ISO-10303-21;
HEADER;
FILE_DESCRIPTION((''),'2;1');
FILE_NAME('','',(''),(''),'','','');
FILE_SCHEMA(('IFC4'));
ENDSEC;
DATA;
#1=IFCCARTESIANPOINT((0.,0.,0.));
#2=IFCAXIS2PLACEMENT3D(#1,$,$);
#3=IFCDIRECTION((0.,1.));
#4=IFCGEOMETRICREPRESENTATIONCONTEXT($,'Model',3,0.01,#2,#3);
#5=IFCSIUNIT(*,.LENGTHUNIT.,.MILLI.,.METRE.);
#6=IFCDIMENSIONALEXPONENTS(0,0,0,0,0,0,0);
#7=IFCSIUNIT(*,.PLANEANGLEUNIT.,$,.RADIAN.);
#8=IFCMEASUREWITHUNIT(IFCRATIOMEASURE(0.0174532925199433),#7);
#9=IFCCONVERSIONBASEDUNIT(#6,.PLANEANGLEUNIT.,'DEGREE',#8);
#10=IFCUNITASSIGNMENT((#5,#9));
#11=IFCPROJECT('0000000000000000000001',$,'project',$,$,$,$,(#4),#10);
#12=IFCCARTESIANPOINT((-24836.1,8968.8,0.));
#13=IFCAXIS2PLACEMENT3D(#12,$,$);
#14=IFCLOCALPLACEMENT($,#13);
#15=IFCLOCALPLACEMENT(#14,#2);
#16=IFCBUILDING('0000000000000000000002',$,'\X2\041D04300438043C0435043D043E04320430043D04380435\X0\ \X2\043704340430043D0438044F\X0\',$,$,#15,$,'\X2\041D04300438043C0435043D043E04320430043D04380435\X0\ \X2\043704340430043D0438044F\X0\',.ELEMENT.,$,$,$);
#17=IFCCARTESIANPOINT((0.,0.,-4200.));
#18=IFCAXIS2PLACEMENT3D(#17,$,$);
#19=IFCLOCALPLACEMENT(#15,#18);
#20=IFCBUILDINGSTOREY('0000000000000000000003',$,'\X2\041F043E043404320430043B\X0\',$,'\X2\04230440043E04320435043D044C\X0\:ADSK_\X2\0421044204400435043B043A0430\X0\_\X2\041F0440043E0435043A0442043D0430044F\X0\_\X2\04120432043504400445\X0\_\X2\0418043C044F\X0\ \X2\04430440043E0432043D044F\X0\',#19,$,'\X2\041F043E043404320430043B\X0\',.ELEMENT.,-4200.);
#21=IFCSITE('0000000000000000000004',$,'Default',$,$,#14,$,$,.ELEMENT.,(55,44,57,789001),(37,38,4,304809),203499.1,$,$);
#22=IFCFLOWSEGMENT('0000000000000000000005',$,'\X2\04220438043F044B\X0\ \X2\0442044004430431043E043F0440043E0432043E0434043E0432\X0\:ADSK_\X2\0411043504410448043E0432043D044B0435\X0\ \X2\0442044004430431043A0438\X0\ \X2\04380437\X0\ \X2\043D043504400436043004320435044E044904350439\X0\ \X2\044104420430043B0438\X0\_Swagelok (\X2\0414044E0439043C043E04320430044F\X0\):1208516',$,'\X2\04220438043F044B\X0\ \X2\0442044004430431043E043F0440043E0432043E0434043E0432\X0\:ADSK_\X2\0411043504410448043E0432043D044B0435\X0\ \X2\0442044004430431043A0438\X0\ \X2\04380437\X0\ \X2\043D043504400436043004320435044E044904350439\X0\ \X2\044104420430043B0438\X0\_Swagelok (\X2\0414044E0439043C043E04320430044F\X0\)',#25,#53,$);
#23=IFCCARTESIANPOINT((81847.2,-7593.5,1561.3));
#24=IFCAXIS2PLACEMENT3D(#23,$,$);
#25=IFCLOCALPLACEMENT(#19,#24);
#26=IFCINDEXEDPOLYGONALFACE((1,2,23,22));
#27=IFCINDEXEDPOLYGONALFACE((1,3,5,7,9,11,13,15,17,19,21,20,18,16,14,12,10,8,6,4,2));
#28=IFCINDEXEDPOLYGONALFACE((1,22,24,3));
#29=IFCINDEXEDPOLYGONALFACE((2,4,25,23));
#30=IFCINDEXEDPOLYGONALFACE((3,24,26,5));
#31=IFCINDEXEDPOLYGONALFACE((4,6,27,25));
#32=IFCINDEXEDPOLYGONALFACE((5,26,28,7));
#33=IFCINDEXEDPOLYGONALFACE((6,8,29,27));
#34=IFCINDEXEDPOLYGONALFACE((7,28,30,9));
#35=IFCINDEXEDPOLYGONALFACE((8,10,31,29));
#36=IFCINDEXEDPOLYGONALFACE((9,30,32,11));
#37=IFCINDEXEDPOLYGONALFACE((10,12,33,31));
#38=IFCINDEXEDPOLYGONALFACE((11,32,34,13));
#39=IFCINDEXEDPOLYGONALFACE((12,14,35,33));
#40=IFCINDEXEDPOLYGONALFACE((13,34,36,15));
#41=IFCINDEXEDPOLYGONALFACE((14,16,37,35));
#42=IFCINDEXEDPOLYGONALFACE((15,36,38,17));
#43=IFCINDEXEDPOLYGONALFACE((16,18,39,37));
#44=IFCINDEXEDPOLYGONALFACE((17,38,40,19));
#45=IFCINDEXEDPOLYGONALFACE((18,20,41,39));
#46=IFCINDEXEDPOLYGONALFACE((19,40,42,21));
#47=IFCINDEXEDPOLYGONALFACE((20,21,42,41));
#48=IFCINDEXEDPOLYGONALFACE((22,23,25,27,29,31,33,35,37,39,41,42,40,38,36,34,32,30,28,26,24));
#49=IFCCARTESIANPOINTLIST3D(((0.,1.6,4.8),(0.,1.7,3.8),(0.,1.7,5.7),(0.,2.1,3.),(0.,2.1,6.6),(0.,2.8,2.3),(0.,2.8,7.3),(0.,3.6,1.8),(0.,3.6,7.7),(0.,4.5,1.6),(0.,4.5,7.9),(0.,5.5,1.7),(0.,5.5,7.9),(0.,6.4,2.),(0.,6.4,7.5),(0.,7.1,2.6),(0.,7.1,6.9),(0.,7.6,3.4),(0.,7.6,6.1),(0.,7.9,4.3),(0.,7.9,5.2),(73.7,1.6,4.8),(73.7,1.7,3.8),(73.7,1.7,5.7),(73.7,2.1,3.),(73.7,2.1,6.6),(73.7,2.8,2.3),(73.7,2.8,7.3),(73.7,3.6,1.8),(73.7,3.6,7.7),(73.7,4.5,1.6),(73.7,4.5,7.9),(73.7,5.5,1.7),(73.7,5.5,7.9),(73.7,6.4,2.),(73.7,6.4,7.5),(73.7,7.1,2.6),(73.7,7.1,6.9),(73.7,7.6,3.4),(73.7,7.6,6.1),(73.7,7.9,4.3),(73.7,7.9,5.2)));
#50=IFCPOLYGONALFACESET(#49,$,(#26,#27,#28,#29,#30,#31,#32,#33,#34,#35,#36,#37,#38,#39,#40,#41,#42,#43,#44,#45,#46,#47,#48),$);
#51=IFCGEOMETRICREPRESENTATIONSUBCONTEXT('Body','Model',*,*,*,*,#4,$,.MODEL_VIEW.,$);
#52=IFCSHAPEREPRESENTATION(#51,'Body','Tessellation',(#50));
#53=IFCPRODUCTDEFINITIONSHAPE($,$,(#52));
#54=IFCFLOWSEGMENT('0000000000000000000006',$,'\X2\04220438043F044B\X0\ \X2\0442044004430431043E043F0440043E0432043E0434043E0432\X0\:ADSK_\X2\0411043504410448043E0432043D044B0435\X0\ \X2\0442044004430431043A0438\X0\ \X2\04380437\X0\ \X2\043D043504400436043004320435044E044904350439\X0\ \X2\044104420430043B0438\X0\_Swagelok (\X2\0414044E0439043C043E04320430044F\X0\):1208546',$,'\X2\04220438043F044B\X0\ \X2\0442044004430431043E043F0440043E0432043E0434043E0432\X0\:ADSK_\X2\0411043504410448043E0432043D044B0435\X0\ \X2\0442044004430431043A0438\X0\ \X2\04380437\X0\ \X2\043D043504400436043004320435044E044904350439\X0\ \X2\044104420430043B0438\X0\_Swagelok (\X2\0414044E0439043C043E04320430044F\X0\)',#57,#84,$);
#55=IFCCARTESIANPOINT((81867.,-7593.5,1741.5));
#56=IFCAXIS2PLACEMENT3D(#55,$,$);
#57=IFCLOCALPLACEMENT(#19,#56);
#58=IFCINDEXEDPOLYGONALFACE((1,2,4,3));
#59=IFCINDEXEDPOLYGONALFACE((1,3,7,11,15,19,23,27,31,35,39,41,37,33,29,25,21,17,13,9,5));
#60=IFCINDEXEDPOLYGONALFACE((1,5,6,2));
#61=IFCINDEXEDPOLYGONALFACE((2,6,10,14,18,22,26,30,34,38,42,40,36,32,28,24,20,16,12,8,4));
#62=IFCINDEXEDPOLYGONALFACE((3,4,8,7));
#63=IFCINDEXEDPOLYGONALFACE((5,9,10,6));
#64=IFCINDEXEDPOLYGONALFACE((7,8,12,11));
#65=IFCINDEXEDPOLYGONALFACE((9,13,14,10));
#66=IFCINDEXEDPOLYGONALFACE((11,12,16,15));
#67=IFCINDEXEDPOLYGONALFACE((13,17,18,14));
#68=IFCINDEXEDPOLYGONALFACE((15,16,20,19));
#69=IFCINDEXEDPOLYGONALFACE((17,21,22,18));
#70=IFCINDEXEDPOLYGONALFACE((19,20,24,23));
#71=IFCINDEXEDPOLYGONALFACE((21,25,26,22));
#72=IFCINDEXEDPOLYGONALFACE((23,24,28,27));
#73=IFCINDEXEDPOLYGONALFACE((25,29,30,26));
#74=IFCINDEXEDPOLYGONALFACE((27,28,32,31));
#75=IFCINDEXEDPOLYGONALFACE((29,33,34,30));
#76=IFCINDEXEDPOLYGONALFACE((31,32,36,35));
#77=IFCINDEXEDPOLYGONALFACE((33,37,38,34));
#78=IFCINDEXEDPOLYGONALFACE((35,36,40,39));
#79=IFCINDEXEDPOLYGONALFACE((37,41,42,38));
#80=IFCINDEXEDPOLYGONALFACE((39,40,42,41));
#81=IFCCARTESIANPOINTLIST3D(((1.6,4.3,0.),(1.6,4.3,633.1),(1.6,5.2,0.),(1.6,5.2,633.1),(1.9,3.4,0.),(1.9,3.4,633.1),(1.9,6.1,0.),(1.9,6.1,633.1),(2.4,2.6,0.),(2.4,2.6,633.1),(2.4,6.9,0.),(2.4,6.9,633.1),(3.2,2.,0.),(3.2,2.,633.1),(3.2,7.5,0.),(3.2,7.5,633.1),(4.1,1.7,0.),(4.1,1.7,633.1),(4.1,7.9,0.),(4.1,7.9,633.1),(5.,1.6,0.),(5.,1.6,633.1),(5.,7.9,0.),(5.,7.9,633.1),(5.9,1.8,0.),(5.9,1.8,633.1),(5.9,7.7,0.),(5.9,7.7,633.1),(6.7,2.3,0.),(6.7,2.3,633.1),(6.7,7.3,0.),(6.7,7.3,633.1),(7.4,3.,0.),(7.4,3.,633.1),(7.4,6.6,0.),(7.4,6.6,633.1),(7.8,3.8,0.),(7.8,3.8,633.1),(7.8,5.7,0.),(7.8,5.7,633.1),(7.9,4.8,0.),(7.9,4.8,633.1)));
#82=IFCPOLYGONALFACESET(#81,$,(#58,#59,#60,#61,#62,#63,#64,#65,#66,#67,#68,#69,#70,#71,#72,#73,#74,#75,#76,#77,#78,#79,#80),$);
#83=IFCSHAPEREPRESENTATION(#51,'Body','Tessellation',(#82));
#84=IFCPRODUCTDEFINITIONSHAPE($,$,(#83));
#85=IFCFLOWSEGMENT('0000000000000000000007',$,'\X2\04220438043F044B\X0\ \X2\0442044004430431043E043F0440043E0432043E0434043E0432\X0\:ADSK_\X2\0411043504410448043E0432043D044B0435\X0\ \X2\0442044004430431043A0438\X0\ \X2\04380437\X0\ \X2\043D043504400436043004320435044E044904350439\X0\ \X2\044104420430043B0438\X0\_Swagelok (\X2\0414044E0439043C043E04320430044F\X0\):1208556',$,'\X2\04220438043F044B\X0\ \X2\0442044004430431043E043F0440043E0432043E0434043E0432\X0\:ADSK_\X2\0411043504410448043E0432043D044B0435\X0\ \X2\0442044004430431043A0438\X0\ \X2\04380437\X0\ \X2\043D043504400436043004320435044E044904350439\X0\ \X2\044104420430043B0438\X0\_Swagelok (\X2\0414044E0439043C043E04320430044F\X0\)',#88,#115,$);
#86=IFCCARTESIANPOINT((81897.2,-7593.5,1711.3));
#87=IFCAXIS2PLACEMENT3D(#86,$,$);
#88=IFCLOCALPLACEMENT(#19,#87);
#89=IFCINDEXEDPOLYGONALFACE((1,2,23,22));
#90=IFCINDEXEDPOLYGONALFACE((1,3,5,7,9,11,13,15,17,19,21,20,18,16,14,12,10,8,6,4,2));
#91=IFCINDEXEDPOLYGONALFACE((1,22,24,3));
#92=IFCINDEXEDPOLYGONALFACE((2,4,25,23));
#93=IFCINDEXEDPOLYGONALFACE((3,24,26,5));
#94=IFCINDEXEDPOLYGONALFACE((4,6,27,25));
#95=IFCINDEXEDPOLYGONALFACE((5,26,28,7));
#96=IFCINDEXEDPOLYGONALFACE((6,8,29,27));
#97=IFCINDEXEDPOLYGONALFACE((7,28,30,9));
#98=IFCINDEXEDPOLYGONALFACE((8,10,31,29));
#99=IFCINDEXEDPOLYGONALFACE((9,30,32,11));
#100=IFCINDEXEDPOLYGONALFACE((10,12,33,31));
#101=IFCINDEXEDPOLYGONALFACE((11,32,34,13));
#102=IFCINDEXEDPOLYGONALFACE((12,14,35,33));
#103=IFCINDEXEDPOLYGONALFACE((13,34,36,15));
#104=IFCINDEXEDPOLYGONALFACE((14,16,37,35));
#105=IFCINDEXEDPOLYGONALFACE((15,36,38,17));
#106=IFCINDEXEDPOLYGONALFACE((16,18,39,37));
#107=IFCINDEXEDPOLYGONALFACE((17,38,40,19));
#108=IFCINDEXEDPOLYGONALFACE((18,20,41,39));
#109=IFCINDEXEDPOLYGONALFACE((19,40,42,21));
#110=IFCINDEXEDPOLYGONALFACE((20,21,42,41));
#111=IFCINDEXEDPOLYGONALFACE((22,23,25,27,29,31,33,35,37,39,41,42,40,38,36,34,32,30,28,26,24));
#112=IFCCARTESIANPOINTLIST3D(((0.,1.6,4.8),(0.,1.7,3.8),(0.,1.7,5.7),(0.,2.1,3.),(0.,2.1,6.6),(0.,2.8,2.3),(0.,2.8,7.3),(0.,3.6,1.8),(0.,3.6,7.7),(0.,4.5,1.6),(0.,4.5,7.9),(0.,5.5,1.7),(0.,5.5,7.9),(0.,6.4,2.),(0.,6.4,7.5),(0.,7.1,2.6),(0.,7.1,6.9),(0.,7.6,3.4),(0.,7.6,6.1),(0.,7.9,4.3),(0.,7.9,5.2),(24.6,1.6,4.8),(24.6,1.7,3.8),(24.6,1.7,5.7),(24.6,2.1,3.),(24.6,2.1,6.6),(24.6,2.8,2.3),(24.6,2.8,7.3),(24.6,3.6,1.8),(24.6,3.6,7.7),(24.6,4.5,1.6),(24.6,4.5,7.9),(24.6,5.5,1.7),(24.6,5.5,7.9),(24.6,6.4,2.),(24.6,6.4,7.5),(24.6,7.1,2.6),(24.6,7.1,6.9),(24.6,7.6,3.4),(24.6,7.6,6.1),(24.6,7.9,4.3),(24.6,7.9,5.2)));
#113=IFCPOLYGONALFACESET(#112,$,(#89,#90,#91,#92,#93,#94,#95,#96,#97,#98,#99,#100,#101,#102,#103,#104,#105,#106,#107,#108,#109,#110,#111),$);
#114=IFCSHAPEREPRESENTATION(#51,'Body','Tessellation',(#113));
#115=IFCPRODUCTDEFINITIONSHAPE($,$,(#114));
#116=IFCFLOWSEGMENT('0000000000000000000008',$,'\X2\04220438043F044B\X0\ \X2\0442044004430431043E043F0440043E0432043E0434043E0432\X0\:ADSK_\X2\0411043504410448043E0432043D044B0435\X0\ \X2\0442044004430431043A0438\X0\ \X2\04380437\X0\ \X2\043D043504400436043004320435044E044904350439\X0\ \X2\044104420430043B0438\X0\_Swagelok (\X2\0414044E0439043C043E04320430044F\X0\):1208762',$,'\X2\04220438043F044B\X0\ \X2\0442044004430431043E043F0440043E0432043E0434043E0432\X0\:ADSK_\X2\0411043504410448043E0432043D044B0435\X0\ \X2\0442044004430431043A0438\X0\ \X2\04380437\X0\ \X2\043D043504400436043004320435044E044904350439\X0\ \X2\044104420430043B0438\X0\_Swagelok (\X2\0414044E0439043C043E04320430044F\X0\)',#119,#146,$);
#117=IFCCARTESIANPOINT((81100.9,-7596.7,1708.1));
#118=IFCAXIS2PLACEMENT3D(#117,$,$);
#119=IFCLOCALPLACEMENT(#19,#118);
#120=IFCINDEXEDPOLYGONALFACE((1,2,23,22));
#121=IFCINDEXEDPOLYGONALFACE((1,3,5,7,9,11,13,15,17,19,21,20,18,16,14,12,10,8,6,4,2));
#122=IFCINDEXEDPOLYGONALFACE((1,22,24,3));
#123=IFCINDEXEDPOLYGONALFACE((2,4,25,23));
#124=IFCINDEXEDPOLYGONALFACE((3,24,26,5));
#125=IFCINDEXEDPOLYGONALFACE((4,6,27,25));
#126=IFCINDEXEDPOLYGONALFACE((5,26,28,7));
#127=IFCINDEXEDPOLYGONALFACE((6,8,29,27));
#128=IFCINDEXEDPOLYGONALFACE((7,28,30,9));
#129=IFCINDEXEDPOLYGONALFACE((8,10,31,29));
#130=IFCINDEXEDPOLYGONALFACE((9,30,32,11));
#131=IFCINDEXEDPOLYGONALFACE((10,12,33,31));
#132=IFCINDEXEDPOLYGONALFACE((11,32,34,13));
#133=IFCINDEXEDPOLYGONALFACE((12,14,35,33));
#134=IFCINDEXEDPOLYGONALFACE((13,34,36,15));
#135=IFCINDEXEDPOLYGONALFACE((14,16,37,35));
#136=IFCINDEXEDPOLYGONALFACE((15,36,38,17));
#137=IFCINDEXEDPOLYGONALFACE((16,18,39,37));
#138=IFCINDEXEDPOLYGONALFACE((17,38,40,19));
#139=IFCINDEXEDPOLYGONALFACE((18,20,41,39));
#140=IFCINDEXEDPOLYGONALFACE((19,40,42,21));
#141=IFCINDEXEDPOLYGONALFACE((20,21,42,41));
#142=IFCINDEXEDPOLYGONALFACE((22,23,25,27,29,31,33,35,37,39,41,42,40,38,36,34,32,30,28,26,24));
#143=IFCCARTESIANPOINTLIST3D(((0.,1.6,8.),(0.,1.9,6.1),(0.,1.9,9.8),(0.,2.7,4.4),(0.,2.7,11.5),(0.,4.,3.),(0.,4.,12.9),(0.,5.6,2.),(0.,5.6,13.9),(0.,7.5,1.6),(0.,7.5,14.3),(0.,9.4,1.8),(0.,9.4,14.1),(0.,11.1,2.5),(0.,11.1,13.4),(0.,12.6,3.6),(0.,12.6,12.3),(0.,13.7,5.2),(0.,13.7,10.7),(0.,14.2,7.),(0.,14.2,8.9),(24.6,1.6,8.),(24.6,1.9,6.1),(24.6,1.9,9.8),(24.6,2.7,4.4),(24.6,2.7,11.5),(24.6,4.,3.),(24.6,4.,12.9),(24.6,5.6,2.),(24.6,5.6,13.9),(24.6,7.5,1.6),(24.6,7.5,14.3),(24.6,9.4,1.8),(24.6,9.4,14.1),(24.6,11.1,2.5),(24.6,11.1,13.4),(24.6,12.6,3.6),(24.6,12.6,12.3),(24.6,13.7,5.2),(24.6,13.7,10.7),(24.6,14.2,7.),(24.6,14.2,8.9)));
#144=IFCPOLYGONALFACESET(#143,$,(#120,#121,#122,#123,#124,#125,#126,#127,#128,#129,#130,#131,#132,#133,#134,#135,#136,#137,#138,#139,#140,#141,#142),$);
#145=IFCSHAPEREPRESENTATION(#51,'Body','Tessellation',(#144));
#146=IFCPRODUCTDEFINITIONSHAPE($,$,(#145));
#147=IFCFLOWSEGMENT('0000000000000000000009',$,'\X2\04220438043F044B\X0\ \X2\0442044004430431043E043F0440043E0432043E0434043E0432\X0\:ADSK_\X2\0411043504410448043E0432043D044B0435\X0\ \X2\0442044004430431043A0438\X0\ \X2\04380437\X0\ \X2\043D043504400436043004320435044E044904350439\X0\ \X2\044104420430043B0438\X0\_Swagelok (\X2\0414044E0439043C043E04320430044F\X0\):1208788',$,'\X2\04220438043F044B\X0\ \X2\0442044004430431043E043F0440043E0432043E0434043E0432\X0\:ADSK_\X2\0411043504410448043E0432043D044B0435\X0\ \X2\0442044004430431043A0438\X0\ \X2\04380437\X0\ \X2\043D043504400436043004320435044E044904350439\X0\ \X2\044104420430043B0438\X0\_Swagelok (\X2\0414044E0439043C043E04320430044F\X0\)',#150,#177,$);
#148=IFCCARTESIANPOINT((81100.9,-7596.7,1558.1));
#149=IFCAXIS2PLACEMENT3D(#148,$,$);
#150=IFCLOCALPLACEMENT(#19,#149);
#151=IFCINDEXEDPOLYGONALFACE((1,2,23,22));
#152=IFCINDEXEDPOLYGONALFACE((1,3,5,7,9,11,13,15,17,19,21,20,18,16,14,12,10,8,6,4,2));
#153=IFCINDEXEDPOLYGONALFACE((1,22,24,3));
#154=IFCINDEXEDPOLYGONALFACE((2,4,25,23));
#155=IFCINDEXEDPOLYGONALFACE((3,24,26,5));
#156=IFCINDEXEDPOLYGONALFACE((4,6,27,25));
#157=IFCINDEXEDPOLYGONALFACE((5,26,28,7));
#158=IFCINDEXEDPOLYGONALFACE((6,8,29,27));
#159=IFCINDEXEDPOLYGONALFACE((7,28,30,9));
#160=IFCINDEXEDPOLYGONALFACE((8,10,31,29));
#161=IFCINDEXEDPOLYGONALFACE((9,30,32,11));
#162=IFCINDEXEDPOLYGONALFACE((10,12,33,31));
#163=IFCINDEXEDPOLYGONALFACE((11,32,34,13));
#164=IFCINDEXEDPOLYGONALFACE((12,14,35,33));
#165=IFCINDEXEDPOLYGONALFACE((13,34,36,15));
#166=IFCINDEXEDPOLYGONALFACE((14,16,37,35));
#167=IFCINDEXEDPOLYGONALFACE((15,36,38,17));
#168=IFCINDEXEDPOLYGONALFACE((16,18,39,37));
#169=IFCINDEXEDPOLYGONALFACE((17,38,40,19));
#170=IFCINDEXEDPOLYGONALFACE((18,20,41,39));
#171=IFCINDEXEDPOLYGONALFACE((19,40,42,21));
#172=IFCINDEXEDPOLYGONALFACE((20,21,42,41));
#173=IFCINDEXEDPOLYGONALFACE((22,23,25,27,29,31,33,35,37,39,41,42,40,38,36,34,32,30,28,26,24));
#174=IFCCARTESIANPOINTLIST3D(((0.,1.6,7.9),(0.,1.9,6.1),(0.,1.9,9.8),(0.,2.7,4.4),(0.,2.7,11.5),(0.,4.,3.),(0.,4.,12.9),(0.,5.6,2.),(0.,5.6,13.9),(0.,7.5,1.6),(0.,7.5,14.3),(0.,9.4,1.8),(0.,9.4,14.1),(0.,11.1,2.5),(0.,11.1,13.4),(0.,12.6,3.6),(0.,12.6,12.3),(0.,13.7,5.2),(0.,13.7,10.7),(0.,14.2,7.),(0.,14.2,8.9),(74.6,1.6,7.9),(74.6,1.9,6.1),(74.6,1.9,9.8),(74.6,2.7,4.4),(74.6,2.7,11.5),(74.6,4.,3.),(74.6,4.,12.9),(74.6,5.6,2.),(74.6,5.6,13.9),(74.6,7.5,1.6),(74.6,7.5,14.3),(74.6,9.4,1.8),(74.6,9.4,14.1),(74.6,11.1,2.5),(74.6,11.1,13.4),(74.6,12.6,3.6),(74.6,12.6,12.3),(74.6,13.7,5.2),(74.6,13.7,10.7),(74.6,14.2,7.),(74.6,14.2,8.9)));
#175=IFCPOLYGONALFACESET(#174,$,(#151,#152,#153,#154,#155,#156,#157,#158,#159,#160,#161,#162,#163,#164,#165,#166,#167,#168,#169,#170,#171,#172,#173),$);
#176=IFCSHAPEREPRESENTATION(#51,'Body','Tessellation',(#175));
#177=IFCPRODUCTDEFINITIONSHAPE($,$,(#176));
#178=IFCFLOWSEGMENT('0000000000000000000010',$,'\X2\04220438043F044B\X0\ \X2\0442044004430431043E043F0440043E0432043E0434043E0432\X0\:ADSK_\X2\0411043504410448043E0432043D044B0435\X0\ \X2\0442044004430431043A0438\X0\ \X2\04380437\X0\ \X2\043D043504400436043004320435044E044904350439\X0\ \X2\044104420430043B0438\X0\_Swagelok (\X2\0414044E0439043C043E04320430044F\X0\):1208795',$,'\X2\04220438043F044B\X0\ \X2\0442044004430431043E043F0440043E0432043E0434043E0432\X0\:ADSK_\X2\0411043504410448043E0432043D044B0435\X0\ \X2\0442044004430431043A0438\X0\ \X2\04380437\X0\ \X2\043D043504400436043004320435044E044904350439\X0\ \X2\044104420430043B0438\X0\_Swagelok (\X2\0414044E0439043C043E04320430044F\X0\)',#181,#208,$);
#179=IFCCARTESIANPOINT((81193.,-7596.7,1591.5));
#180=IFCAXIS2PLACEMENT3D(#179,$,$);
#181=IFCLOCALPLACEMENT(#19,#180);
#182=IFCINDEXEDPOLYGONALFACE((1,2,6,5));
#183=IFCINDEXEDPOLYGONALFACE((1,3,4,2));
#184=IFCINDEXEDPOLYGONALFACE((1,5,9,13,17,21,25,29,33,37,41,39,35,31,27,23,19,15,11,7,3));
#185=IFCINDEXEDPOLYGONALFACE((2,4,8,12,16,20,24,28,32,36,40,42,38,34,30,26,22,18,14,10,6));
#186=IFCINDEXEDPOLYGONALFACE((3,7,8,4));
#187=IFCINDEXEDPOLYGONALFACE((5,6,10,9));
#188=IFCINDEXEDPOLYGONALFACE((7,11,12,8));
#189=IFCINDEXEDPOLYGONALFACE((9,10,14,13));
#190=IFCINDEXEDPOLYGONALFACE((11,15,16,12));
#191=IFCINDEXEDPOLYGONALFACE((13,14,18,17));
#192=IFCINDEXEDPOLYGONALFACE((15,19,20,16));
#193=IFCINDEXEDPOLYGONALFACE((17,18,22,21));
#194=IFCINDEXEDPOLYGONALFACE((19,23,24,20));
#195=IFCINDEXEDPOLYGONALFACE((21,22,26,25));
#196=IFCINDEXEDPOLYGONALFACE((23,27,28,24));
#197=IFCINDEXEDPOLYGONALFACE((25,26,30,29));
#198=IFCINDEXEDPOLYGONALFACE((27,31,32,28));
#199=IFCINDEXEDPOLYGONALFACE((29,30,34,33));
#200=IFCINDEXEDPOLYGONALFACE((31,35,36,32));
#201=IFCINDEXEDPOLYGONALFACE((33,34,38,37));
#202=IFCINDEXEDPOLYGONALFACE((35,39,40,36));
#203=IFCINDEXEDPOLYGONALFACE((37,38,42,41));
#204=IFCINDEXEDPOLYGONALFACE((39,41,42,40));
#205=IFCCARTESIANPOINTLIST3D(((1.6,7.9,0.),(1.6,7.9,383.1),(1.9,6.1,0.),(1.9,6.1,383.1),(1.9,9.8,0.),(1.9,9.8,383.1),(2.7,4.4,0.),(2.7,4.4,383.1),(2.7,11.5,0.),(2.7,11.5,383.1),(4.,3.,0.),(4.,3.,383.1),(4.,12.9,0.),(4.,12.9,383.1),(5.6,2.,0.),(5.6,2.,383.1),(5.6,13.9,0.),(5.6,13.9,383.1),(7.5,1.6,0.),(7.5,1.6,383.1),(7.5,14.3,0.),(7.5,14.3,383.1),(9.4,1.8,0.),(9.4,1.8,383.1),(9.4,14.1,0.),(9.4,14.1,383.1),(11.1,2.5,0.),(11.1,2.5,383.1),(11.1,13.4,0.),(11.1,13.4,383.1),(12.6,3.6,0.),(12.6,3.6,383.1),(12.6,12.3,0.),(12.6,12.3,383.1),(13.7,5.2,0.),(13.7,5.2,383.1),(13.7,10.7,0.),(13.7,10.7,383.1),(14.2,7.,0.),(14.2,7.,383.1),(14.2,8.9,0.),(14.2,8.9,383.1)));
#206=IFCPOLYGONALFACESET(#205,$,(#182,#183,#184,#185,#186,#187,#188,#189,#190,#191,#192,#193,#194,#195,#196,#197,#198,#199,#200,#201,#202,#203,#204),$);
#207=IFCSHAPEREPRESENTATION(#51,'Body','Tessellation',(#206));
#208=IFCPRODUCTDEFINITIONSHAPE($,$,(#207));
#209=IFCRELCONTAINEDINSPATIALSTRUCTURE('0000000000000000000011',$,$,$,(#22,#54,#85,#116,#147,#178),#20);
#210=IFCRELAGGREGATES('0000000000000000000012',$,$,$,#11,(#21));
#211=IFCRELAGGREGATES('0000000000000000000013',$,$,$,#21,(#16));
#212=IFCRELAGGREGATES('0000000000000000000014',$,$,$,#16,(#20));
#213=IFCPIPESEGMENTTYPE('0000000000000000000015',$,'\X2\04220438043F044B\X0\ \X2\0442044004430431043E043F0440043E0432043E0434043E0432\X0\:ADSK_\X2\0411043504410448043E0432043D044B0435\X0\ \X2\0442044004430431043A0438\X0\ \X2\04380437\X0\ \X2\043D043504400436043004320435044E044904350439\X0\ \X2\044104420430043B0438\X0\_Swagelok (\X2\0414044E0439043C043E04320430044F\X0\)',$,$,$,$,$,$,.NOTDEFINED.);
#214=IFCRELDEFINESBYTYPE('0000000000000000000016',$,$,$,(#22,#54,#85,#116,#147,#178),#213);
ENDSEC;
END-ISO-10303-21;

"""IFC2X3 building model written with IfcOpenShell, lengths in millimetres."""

from ifc_helpers import new_model, entity, si_unit, converted_unit, direction, frame, origin, origin_2d_with_axis, place, context, subcontext, project, spatial, circle, extrude, type_object, element, save


model = new_model("IFC2X3")

# Units and contexts
model_context = context("Model", 3, precision=0.01, world=origin(), true_north=direction((0.0, 1.0)))
body_context = subcontext(model_context, "Body", "Model", "MODEL_VIEW")
ifc_project = project(units=[si_unit("LENGTHUNIT", "METRE", prefix="MILLI"), converted_unit("PLANEANGLEUNIT", "DEGREE", entity("IfcRatioMeasure", 0.0174532925199433), si_unit("PLANEANGLEUNIT", "RADIAN"), dimensions=[0, 0, 0, 0, 0, 0, 0])], contexts=[model_context])

# Site, building, storey
site_placement = place(None, frame((-24836.1, 8968.8, 0.0)))
site = spatial("IfcSite", under=ifc_project, at=site_placement, Name="Default", CompositionType="ELEMENT", RefLatitude=(55, 44, 57, 789001), RefLongitude=(37, 38, 4, 304809), RefElevation=203499.1)
building_placement = place(site_placement, origin())
building = spatial("IfcBuilding", under=site, at=building_placement, Name="Наименование здания", LongName="Наименование здания", CompositionType="ELEMENT")
storey_placement = place(building_placement, frame((0.0, 0.0, -4200.0)))
storey = spatial("IfcBuildingStorey", under=building, at=storey_placement, Name="Подвал", ObjectType="Уровень:ADSK_Стрелка_Проектная_Вверх_Имя уровня", LongName="Подвал", CompositionType="ELEMENT", Elevation=-4200.0)

# Flow segments
pipe_segment_type = type_object("IfcPipeSegmentType", Name="Типы трубопроводов:ADSK_Бесшовные трубки из нержавеющей стали_Swagelok (Дюймовая)", PredefinedType="NOTDEFINED")
flow_segment_1_placement = place(storey_placement, frame((81847.2, -7593.5, 1561.3)))
element("IfcFlowSegment", 1, at=flow_segment_1_placement, inside=storey, type_object=pipe_segment_type, Name="Типы трубопроводов:ADSK_Бесшовные трубки из нержавеющей стали_Swagelok (Дюймовая):1208516", ObjectType="Типы трубопроводов:ADSK_Бесшовные трубки из нержавеющей стали_Swagelok (Дюймовая)", context=body_context, shape_type="SweptSolid", body=[
    extrude(circle(Radius=3.2, at=origin_2d_with_axis()), frame((0.0, 4.8, 4.8), z_axis=(1.0, 0.0, 0.0), x_axis=(0.0, -1.0, 0.0)), (0.0, 0.0, 1.0), 73.7),
])
flow_segment_2_placement = place(storey_placement, frame((81867.0, -7593.5, 1741.5)))
element("IfcFlowSegment", 2, at=flow_segment_2_placement, inside=storey, type_object=pipe_segment_type, Name="Типы трубопроводов:ADSK_Бесшовные трубки из нержавеющей стали_Swagelok (Дюймовая):1208546", ObjectType="Типы трубопроводов:ADSK_Бесшовные трубки из нержавеющей стали_Swagelok (Дюймовая)", context=body_context, shape_type="SweptSolid", body=[
    extrude(circle(Radius=3.2, at=origin_2d_with_axis()), frame((4.8, 4.8, 0.0)), (0.0, 0.0, 1.0), 633.1),
])
flow_segment_3_placement = place(storey_placement, frame((81897.2, -7593.5, 1711.3)))
element("IfcFlowSegment", 3, at=flow_segment_3_placement, inside=storey, type_object=pipe_segment_type, Name="Типы трубопроводов:ADSK_Бесшовные трубки из нержавеющей стали_Swagelok (Дюймовая):1208556", ObjectType="Типы трубопроводов:ADSK_Бесшовные трубки из нержавеющей стали_Swagelok (Дюймовая)", context=body_context, shape_type="SweptSolid", body=[
    extrude(circle(Radius=3.2, at=origin_2d_with_axis()), frame((0.0, 4.8, 4.8), z_axis=(1.0, 0.0, 0.0), x_axis=(0.0, -1.0, 0.0)), (0.0, 0.0, 1.0), 24.6),
])
flow_segment_4_placement = place(storey_placement, frame((81100.9, -7596.7, 1708.1)))
element("IfcFlowSegment", 4, at=flow_segment_4_placement, inside=storey, type_object=pipe_segment_type, Name="Типы трубопроводов:ADSK_Бесшовные трубки из нержавеющей стали_Swagelok (Дюймовая):1208762", ObjectType="Типы трубопроводов:ADSK_Бесшовные трубки из нержавеющей стали_Swagelok (Дюймовая)", context=body_context, shape_type="SweptSolid", body=[
    extrude(circle(Radius=6.3, at=origin_2d_with_axis()), frame((0.0, 8.0, 8.0), z_axis=(1.0, 0.0, 0.0), x_axis=(0.0, -1.0, 0.0)), (0.0, 0.0, 1.0), 24.6),
])
flow_segment_5_placement = place(storey_placement, frame((81100.9, -7596.7, 1558.1)))
element("IfcFlowSegment", 5, at=flow_segment_5_placement, inside=storey, type_object=pipe_segment_type, Name="Типы трубопроводов:ADSK_Бесшовные трубки из нержавеющей стали_Swagelok (Дюймовая):1208788", ObjectType="Типы трубопроводов:ADSK_Бесшовные трубки из нержавеющей стали_Swagelok (Дюймовая)", context=body_context, shape_type="SweptSolid", body=[
    extrude(circle(Radius=6.3, at=origin_2d_with_axis()), frame((0.0, 8.0, 8.0), z_axis=(1.0, 0.0, 0.0), x_axis=(0.0, -1.0, 0.0)), (0.0, 0.0, 1.0), 74.6),
])
flow_segment_6_placement = place(storey_placement, frame((81193.0, -7596.7, 1591.5)))
element("IfcFlowSegment", 6, at=flow_segment_6_placement, inside=storey, type_object=pipe_segment_type, Name="Типы трубопроводов:ADSK_Бесшовные трубки из нержавеющей стали_Swagelok (Дюймовая):1208795", ObjectType="Типы трубопроводов:ADSK_Бесшовные трубки из нержавеющей стали_Swagelok (Дюймовая)", context=body_context, shape_type="SweptSolid", body=[
    extrude(circle(Radius=6.3, at=origin_2d_with_axis()), frame((8.0, 8.0, 0.0), z_axis=(0.0, 0.0, 1.0), x_axis=(-1.0, 0.0, 0.0)), (0.0, 0.0, 1.0), 383.1),
])

save(model, "model.ifc")
